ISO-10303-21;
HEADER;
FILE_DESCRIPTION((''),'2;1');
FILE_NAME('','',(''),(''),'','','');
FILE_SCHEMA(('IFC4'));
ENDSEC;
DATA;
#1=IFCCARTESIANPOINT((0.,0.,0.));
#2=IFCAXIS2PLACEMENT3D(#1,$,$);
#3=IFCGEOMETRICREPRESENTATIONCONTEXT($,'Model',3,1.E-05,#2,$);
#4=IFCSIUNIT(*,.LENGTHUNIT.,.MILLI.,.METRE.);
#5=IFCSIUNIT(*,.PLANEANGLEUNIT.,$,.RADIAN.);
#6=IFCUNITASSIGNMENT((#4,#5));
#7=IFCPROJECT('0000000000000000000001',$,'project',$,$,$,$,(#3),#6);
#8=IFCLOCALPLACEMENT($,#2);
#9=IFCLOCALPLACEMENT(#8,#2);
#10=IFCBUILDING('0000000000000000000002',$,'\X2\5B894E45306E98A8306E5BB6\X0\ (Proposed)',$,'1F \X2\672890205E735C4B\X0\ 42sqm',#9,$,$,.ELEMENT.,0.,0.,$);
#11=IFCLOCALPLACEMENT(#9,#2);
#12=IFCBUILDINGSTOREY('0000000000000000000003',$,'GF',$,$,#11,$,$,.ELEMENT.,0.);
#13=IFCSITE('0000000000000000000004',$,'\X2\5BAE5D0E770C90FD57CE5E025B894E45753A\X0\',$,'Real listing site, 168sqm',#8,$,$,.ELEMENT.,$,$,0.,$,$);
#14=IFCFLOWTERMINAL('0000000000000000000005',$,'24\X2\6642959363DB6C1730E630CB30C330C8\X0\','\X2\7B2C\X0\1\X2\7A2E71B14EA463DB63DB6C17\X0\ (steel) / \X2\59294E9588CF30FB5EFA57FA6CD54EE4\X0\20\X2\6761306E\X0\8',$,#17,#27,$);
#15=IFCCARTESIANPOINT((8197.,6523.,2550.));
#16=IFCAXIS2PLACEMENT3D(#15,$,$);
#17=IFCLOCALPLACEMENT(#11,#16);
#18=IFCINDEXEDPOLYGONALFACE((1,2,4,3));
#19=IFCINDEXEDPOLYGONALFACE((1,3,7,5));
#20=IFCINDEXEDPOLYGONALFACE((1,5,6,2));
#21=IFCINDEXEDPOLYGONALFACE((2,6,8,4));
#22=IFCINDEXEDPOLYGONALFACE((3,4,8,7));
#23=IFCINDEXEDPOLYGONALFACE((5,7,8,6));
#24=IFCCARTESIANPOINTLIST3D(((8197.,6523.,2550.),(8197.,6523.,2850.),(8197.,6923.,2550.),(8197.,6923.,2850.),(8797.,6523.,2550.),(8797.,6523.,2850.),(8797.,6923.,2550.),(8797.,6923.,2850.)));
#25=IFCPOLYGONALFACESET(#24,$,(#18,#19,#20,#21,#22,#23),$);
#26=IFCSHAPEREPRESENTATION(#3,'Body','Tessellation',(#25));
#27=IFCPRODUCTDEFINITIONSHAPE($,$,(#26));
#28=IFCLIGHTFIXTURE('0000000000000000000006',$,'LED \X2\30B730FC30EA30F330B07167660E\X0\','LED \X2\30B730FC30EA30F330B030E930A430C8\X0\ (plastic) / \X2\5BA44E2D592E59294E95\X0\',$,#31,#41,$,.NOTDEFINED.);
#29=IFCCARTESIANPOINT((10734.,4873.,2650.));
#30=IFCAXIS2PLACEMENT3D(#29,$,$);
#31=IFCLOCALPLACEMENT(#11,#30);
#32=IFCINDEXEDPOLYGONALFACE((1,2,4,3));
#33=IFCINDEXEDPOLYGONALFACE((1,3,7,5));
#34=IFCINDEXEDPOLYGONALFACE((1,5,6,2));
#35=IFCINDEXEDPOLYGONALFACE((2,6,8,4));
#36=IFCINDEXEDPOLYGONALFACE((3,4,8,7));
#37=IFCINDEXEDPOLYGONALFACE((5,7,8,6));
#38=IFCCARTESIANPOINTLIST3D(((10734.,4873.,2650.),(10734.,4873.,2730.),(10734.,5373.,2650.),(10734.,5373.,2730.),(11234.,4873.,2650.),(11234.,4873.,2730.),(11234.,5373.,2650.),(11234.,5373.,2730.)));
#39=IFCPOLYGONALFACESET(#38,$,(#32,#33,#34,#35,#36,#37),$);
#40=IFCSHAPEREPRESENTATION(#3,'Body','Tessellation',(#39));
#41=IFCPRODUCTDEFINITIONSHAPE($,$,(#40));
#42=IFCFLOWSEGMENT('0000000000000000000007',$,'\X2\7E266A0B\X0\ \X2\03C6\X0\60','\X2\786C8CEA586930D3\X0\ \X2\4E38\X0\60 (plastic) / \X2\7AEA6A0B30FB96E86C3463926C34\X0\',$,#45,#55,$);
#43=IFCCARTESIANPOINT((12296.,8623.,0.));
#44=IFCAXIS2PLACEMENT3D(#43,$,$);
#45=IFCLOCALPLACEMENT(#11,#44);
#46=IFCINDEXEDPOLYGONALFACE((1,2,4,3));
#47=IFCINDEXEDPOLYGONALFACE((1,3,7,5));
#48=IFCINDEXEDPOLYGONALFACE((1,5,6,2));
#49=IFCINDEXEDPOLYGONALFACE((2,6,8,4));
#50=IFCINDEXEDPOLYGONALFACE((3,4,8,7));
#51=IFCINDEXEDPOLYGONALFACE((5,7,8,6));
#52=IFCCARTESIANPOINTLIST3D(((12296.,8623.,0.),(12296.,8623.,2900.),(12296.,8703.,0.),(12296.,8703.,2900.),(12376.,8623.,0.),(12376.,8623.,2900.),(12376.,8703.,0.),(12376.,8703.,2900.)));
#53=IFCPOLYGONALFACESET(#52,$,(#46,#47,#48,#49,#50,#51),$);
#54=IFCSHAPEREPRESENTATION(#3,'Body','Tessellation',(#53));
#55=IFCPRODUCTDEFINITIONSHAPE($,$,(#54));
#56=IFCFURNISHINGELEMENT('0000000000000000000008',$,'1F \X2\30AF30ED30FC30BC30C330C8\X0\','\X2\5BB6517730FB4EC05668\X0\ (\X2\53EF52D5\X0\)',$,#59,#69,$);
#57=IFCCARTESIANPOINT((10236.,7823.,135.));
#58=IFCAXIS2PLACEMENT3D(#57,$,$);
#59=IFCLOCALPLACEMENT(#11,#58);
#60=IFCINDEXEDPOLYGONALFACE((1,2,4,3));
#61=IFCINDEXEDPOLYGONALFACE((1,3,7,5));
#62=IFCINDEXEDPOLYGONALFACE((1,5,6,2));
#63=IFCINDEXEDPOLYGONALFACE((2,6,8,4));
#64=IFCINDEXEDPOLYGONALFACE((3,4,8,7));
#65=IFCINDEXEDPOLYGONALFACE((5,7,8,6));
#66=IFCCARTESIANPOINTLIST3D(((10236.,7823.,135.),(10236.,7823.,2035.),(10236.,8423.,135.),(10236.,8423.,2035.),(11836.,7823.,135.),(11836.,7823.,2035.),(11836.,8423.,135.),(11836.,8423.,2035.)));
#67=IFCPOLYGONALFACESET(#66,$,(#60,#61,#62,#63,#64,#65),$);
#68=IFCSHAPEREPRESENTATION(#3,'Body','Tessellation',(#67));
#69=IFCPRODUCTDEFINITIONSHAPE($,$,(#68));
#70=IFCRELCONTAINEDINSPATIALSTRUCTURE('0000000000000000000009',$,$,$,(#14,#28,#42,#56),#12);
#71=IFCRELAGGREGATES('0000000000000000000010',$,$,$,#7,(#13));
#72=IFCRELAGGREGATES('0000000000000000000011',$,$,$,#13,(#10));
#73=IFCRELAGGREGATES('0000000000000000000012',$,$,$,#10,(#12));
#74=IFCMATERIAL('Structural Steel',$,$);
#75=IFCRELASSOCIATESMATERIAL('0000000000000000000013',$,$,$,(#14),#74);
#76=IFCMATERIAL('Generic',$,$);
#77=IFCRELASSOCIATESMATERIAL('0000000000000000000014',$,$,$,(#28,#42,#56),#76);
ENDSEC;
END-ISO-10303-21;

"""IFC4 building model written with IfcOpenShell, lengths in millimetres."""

from ifc_helpers import new_model, si_unit, frame, frame_2d, origin, place, context, project, spatial, rectangle, extrude, material, element, save


model = new_model("IFC4")

# Units and contexts
model_context = context("Model", 3, precision=1e-05, world=origin())
ifc_project = project(units=[si_unit("LENGTHUNIT", "METRE", prefix="MILLI"), si_unit("PLANEANGLEUNIT", "RADIAN")], contexts=[model_context])

# Site, building, storey
site_placement = place(None, origin())
site = spatial("IfcSite", under=ifc_project, at=site_placement, Name="宮崎県都城市安久町", ObjectType="Real listing site, 168sqm", CompositionType="ELEMENT", RefElevation=0.0)
building_placement = place(site_placement, origin())
building = spatial("IfcBuilding", under=site, at=building_placement, Name="安久の風の家 (Proposed)", ObjectType="1F 木造平屋 42sqm", CompositionType="ELEMENT", ElevationOfRefHeight=0.0, ElevationOfTerrain=0.0)
storey_placement = place(building_placement, origin())
storey = spatial("IfcBuildingStorey", under=building, at=storey_placement, Name="GF", CompositionType="ELEMENT", Elevation=0.0)

# Shared definitions
ifc_material_1 = material(Name="Generic")

# Flow terminal
ifc_material_2 = material(Name="Structural Steel")
flow_terminal_placement = place(storey_placement, frame((8197.0, 6523.0, 2550.0)))
element("IfcFlowTerminal", 1, at=flow_terminal_placement, inside=storey, material=ifc_material_2, Name="24時間換気ユニット", Description="第1種熱交換換気 (steel) / 天井裏・建基法令20条の8", context=model_context, shape_type="SweptSolid", body=[
    extrude(rectangle(XDim=600.0, YDim=400.0, at=frame_2d((300.0, 200.0))), frame((8197.0, 6523.0, 2550.0)), (0.0, 0.0, 1.0), 300.0),
])

# Light fixture
light_fixture_placement = place(storey_placement, frame((10734.0, 4873.0, 2650.0)))
element("IfcLightFixture", 2, at=light_fixture_placement, inside=storey, material=ifc_material_1, Name="LED シーリング照明", Description="LED シーリングライト (plastic) / 室中央天井", PredefinedType="NOTDEFINED", context=model_context, shape_type="SweptSolid", body=[
    extrude(rectangle(XDim=500.0, YDim=500.0, at=frame_2d((250.0, 250.0))), frame((10734.0, 4873.0, 2650.0)), (0.0, 0.0, 1.0), 80.0),
])

# Flow segment
flow_segment_placement = place(storey_placement, frame((12296.0, 8623.0, 0.0)))
element("IfcFlowSegment", 3, at=flow_segment_placement, inside=storey, material=ifc_material_1, Name="縦樋 φ60", Description="硬質塩ビ 丸60 (plastic) / 竪樋・雨水排水", context=model_context, shape_type="SweptSolid", body=[
    extrude(rectangle(XDim=80.0, YDim=80.0, at=frame_2d((40.0, 40.0))), frame((12296.0, 8623.0, 0.0)), (0.0, 0.0, 1.0), 2900.0),
])

# Furnishing element
furnishing_placement = place(storey_placement, frame((10236.0, 7823.0, 135.0)))
element("IfcFurnishingElement", 4, at=furnishing_placement, inside=storey, material=ifc_material_1, Name="1F クローゼット", Description="家具・什器 (可動)", context=model_context, shape_type="SweptSolid", body=[
    extrude(rectangle(XDim=1600.0, YDim=600.0, at=frame_2d((800.0, 300.0))), frame((10236.0, 7823.0, 135.0)), (0.0, 0.0, 1.0), 1900.0),
])

save(model, "model.ifc")
